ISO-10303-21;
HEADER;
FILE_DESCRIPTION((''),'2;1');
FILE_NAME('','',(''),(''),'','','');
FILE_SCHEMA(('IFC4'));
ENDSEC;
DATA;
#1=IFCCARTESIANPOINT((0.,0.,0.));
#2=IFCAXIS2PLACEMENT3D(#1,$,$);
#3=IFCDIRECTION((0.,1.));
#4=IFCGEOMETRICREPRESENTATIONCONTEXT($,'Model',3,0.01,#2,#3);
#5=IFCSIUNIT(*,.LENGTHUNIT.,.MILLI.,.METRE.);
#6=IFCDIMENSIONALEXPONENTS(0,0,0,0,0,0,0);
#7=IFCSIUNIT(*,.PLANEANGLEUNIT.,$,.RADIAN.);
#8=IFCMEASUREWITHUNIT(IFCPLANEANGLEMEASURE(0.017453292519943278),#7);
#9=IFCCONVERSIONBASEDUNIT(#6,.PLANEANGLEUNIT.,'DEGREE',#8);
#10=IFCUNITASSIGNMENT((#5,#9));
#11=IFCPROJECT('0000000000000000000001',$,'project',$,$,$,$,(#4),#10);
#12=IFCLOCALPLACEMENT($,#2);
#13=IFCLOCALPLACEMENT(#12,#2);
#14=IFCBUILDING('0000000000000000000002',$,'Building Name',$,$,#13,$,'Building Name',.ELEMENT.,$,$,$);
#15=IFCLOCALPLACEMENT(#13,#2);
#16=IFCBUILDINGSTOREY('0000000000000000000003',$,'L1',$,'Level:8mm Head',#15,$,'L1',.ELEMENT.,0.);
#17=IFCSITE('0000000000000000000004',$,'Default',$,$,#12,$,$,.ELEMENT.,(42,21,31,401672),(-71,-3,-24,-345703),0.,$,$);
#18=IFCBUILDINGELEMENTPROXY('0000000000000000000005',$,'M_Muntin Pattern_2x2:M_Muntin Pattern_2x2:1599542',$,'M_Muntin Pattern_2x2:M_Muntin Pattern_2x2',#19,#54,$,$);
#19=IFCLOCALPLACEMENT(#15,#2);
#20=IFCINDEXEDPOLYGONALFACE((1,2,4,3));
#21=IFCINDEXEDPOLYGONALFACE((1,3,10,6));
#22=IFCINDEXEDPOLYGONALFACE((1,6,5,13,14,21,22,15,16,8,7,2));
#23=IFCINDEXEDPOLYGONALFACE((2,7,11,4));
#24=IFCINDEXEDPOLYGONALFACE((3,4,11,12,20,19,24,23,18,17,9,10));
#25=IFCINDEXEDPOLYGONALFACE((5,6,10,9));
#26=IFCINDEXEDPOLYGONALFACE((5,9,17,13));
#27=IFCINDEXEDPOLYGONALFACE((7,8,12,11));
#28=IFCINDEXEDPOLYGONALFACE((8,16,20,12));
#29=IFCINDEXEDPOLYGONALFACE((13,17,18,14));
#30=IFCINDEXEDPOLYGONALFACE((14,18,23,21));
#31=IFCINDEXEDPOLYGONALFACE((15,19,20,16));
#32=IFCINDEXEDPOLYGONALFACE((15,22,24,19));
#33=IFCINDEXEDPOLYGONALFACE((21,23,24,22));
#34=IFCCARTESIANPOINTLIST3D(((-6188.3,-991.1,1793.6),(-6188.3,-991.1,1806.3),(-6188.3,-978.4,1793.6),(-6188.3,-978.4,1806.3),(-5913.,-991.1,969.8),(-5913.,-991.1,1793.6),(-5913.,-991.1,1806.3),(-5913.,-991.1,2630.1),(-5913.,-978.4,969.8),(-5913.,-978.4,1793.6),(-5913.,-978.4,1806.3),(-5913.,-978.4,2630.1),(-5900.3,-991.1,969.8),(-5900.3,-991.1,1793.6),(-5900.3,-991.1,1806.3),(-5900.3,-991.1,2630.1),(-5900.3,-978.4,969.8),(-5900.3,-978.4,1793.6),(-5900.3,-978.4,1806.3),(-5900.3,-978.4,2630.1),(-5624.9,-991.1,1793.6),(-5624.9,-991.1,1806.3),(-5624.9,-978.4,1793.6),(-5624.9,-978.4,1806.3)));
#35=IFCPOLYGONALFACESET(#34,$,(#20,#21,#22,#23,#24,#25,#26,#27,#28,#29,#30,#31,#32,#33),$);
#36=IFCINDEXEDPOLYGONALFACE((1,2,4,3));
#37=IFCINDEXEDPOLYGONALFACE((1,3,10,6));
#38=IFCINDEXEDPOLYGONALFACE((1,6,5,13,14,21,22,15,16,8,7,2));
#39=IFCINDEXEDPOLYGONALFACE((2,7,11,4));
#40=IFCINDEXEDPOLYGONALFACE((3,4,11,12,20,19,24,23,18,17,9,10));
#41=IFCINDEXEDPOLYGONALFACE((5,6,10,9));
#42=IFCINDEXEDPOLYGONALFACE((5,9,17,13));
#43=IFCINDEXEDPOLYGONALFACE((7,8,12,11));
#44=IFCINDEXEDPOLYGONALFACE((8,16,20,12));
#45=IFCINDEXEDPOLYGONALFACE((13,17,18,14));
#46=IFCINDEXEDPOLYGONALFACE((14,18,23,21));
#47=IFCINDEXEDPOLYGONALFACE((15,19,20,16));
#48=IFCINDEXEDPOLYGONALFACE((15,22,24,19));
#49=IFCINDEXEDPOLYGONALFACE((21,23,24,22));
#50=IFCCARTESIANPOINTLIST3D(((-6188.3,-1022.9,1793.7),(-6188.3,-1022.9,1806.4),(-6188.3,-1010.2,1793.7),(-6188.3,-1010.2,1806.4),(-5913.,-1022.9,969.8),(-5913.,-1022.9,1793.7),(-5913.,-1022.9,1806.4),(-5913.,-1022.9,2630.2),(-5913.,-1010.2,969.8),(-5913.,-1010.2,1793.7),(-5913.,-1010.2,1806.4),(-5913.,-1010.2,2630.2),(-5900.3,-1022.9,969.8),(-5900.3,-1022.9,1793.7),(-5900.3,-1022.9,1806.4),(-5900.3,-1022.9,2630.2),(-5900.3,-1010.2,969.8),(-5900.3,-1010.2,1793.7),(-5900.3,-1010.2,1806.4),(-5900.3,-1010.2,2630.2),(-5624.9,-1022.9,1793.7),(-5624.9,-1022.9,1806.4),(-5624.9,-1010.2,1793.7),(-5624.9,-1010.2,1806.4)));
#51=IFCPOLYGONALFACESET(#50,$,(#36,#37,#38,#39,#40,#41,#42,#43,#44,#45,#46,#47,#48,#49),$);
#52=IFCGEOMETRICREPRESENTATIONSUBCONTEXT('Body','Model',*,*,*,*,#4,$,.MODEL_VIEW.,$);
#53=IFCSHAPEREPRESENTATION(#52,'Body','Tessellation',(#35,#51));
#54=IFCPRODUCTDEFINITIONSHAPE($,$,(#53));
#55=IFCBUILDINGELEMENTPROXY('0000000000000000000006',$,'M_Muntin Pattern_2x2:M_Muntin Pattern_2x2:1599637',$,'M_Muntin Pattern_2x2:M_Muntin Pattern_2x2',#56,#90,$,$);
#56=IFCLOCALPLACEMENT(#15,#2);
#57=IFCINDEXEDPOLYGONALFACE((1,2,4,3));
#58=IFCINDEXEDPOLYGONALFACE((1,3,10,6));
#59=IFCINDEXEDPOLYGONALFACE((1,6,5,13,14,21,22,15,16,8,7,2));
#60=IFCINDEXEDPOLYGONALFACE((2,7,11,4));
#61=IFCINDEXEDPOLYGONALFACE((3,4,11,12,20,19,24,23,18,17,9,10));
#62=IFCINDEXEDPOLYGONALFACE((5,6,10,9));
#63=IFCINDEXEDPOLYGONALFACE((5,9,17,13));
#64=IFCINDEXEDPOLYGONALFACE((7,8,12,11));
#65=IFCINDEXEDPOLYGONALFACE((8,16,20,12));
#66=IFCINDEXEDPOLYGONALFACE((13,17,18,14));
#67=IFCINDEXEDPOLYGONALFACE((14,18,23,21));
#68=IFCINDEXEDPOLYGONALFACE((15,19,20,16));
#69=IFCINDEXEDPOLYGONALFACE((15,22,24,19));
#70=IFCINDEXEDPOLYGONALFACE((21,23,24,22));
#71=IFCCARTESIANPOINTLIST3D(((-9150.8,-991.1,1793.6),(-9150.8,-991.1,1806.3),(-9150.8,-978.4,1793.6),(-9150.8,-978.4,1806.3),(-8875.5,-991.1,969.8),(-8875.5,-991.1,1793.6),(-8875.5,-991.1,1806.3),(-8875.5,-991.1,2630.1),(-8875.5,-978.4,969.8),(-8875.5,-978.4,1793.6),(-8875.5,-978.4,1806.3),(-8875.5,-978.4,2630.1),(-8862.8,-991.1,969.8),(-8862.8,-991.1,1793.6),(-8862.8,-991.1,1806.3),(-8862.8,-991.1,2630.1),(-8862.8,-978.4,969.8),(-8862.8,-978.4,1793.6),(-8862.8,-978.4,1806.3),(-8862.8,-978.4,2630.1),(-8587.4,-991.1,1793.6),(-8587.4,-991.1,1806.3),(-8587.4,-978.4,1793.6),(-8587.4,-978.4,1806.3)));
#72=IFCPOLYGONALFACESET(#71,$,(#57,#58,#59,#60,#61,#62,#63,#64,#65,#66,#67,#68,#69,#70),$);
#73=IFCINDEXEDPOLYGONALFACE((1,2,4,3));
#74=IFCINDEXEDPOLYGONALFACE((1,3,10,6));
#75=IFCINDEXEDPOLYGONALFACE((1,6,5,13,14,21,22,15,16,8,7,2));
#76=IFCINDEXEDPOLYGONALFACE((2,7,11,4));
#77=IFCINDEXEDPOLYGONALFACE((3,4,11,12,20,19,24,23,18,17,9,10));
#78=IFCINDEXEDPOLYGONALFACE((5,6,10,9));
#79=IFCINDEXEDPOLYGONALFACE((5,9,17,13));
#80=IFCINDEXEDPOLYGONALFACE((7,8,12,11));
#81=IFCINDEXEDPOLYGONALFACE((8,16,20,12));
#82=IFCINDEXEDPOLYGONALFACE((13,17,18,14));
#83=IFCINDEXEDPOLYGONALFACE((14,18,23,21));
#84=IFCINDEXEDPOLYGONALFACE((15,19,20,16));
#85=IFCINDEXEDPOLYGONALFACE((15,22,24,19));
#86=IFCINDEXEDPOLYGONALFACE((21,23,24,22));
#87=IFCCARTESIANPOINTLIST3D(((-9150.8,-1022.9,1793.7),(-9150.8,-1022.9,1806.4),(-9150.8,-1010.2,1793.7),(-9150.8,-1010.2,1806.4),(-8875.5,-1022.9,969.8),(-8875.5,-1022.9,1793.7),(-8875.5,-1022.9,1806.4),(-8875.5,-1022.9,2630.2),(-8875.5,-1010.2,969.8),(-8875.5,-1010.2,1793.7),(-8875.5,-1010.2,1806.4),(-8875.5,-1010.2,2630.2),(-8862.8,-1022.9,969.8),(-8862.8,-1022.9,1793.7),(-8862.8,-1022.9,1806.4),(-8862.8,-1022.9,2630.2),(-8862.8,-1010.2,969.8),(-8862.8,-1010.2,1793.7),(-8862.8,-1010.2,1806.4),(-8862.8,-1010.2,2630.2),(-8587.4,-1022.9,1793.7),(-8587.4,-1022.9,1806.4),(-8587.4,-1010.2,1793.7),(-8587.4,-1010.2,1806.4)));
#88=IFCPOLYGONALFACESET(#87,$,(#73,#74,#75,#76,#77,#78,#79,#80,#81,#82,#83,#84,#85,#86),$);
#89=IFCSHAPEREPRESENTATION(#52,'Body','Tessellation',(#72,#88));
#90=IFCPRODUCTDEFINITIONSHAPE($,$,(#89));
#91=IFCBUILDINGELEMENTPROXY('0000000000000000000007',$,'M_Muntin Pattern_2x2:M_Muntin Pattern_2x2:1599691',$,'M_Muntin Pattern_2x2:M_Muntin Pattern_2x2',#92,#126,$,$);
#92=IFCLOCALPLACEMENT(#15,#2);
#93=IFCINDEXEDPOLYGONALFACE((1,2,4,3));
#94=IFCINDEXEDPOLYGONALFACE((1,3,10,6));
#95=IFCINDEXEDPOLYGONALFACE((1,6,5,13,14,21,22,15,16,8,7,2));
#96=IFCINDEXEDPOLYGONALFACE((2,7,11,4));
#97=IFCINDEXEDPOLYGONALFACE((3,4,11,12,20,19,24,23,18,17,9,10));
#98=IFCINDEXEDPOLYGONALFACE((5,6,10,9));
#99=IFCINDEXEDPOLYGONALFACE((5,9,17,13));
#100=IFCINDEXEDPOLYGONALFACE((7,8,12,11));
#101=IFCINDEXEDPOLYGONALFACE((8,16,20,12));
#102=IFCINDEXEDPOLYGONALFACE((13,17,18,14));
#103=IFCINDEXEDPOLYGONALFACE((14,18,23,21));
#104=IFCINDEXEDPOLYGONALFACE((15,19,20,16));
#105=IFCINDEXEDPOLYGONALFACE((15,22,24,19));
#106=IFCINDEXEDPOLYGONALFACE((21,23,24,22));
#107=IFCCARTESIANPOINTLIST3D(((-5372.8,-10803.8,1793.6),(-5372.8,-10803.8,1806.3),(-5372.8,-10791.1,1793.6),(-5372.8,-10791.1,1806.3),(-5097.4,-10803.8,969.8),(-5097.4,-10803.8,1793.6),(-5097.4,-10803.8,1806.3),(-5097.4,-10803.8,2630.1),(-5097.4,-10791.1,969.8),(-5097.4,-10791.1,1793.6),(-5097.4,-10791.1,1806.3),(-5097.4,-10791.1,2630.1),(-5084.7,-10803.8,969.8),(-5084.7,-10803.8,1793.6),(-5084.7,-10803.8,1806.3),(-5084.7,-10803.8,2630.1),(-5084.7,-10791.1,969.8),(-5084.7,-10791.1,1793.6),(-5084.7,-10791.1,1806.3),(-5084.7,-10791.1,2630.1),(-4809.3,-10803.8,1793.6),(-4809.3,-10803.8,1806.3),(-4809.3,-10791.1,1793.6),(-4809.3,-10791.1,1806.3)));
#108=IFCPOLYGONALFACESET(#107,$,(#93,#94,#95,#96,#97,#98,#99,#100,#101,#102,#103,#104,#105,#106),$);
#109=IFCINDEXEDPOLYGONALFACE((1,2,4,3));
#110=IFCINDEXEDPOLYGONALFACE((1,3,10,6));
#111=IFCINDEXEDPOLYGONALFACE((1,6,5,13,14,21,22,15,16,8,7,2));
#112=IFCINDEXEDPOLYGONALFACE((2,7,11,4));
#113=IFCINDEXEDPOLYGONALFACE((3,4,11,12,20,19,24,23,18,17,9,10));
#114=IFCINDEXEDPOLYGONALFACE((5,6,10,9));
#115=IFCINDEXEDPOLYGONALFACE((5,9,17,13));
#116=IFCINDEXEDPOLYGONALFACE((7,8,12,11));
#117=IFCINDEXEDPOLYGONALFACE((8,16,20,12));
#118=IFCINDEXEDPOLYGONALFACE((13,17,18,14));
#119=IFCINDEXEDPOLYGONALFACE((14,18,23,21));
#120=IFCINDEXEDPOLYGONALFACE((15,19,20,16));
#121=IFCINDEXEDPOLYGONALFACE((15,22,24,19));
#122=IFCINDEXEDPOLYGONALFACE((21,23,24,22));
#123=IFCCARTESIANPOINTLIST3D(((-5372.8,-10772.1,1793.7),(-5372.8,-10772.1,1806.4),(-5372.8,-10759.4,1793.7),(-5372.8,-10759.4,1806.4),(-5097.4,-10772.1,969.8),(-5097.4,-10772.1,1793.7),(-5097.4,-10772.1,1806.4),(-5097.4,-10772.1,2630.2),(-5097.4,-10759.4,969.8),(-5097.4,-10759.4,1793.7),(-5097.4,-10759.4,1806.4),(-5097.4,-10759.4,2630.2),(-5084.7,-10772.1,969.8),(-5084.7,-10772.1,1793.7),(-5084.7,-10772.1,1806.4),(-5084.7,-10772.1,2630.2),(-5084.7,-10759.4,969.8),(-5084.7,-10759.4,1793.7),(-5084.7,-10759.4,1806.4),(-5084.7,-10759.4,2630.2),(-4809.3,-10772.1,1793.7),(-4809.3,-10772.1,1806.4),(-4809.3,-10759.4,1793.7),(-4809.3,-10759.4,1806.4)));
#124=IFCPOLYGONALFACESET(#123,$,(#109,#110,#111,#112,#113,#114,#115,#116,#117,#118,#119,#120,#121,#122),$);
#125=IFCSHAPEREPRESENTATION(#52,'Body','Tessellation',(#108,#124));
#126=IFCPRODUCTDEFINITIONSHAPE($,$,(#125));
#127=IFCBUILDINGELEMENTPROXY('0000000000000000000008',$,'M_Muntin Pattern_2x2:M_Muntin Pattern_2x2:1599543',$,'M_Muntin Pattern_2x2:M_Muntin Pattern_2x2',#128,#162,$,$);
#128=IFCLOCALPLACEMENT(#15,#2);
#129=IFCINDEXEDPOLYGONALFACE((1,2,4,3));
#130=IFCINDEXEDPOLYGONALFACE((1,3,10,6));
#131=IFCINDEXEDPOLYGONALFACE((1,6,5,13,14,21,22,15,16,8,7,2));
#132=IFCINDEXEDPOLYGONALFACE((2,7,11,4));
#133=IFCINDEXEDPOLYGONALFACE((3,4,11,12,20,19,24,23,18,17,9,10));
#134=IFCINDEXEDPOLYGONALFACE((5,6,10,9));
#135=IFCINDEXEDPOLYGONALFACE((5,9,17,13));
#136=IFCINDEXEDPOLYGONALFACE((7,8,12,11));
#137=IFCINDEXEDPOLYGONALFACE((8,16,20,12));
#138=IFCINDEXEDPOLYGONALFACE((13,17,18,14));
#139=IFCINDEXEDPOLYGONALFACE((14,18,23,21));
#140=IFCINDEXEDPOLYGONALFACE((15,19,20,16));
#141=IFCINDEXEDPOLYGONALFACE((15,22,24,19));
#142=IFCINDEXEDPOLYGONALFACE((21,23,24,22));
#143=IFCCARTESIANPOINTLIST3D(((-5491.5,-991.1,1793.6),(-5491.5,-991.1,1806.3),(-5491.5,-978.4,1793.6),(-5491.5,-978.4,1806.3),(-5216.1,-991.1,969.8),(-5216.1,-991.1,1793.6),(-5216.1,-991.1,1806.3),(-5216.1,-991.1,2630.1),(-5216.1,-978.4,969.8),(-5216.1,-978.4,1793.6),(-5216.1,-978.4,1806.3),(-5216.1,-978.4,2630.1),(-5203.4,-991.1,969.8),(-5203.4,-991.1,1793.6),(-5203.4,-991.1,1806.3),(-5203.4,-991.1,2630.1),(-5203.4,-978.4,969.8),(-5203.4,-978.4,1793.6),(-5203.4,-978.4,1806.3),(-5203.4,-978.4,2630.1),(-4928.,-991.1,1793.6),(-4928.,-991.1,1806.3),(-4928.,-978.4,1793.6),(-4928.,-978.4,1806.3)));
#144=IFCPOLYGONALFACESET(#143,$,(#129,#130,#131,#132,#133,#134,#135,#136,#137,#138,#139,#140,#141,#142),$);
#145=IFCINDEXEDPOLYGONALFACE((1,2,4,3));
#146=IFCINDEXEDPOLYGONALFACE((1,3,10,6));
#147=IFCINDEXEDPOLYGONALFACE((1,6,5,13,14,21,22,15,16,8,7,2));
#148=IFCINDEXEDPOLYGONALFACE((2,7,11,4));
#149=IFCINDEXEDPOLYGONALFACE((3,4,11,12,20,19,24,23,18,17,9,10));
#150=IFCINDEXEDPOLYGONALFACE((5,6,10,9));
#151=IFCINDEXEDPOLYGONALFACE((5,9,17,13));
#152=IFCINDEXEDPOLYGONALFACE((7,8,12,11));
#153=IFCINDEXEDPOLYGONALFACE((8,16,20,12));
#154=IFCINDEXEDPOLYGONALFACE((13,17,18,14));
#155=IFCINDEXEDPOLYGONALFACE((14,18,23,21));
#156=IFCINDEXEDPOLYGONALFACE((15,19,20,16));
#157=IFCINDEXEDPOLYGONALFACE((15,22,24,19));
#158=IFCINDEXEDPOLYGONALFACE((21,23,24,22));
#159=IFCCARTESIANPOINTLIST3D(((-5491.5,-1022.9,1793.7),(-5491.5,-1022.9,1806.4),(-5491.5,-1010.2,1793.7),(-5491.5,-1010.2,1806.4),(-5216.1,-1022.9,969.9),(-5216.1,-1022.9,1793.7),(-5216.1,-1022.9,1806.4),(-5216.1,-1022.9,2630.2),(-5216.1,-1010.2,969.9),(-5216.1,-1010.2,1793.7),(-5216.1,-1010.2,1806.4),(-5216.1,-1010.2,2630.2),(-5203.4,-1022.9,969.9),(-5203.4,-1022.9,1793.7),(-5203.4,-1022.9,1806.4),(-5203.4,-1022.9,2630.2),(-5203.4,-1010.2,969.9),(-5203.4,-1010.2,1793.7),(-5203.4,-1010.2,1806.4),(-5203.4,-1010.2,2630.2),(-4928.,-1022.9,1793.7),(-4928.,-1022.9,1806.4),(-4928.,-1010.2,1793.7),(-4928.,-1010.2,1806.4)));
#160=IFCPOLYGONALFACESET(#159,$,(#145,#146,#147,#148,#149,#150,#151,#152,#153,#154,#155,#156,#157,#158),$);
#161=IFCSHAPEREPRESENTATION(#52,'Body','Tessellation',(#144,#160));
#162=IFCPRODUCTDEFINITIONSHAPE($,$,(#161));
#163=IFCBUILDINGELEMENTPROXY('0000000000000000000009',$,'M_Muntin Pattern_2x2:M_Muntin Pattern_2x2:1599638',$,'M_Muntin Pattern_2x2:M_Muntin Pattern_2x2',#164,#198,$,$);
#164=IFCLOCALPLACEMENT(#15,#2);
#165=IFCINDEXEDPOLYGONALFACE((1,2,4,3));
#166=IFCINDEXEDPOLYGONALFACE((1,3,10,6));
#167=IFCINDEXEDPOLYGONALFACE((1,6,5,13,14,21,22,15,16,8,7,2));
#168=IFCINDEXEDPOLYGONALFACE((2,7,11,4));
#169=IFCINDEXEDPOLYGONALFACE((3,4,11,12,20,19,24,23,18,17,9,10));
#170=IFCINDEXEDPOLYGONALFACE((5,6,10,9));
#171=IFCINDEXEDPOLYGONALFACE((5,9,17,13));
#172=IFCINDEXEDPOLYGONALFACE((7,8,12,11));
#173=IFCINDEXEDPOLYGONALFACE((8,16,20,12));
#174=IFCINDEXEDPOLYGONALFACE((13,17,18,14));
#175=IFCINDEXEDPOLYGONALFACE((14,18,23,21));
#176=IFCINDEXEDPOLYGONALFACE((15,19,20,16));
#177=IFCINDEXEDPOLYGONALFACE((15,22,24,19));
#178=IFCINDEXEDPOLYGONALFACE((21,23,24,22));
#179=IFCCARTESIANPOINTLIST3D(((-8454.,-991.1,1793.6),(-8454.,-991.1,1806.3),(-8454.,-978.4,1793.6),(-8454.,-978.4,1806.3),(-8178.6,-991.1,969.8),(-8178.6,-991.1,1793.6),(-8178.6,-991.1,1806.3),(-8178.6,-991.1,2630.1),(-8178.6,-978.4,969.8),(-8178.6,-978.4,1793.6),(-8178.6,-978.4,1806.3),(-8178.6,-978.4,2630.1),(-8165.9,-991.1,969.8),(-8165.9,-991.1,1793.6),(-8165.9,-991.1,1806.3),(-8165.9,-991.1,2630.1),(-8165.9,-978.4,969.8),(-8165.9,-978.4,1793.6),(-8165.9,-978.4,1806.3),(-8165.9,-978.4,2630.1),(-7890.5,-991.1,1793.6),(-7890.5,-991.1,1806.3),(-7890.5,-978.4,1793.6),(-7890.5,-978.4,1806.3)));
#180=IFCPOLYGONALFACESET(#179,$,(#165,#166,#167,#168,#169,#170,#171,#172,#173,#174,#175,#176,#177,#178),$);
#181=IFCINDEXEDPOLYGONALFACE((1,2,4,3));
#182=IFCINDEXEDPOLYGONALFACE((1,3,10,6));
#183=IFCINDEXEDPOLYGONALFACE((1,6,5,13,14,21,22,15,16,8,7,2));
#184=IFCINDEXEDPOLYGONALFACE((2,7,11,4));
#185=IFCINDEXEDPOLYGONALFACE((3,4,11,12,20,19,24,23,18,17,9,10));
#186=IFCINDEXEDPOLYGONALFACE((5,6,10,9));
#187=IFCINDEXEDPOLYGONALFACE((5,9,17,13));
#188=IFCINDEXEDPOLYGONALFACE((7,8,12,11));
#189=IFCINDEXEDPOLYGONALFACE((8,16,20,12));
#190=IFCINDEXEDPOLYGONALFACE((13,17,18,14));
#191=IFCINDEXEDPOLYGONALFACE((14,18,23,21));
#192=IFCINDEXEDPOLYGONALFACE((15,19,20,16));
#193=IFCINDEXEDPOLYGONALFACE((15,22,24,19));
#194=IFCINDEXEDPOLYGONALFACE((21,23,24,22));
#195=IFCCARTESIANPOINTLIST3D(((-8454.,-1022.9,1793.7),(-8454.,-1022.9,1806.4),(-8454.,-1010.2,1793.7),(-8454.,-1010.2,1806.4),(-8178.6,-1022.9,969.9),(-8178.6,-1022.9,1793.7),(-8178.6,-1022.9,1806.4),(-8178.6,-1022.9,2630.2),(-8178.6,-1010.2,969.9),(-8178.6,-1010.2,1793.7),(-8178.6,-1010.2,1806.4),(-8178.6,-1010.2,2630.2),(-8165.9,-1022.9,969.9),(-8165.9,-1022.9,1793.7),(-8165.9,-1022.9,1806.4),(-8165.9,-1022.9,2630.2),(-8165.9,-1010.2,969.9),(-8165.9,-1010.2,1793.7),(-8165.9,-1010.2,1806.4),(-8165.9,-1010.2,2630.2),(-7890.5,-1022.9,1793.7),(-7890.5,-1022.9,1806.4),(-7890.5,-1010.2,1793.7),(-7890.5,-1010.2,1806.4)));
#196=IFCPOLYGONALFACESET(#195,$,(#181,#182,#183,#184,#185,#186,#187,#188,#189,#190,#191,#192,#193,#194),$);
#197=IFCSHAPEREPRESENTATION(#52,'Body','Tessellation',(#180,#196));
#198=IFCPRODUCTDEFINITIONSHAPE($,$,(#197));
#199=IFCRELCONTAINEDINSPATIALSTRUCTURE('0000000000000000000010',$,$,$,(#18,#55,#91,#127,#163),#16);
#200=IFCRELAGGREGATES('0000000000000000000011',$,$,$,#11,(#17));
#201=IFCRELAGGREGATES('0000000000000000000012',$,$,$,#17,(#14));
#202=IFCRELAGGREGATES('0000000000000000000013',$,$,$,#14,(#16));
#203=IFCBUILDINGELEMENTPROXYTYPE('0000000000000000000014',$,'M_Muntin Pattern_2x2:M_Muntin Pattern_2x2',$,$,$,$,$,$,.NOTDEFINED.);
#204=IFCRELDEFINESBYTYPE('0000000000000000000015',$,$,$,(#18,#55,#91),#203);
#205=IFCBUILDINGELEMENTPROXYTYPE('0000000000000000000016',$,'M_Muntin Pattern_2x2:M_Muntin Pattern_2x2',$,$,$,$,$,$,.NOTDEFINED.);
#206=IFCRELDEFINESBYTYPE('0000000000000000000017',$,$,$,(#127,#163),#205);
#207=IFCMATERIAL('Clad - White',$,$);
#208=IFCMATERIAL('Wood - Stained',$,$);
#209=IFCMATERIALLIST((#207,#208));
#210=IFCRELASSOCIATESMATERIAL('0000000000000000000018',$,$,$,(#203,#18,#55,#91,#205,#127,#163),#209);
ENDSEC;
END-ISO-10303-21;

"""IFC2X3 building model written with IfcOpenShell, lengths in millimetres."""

from ifc_helpers import new_model, entity, si_unit, converted_unit, direction, frame, origin, place, context, subcontext, project, spatial, polyline, outline, extrude, source, transform, mapped, material, material_list, type_object, type_shapes, element, save


model = new_model("IFC2X3")

# Units and contexts
model_context = context("Model", 3, precision=0.01, world=origin(), true_north=direction((0.0, 1.0)))
body_context = subcontext(model_context, "Body", "Model", "MODEL_VIEW")
ifc_project = project(units=[si_unit("LENGTHUNIT", "METRE", prefix="MILLI"), converted_unit("PLANEANGLEUNIT", "DEGREE", entity("IfcPlaneAngleMeasure", 0.017453292519943278), si_unit("PLANEANGLEUNIT", "RADIAN"), dimensions=[0, 0, 0, 0, 0, 0, 0])], contexts=[model_context])

# Site, building, storey
site_placement = place(None, origin())
site = spatial("IfcSite", under=ifc_project, at=site_placement, Name="Default", CompositionType="ELEMENT", RefLatitude=(42, 21, 31, 401672), RefLongitude=(-71, -3, -24, -345703), RefElevation=0.0)
building_placement = place(site_placement, origin())
building = spatial("IfcBuilding", under=site, at=building_placement, Name="Building Name", LongName="Building Name", CompositionType="ELEMENT")
storey_placement = place(building_placement, origin())
storey = spatial("IfcBuildingStorey", under=building, at=storey_placement, Name="L1", ObjectType="Level:8mm Head", LongName="L1", CompositionType="ELEMENT", Elevation=0.0)

# Building element proxies
ifc_material_1 = material(Name="Clad - White")
ifc_material_2 = material(Name="Wood - Stained")
ifc_material_list = material_list([ifc_material_1, ifc_material_2])
building_element_proxy_type_1 = type_object("IfcBuildingElementProxyType", Name="M_Muntin Pattern_2x2:M_Muntin Pattern_2x2", PredefinedType="NOTDEFINED", material=ifc_material_list)
shared_shape_1 = source(origin(), body_context, "Body", "SweptSolid", [
    extrude(outline(polyline([(6.4, -6.4), (830.1, -6.4), (830.1, 6.3), (6.4, 6.3), (6.4, 281.7), (-6.3, 281.7), (-6.3, 6.3), (-830.2, 6.3), (-830.2, -6.4), (-6.3, -6.4), (-6.3, -281.7), (6.4, -281.7), (6.4, -6.4)])), frame((0.0, 9.5, 830.1), z_axis=(0.0, 1.0, 0.0), x_axis=(0.0, 0.0, 1.0)), (0.0, 0.0, 1.0), 12.7),
    extrude(outline(polyline([(6.4, -6.4), (830.2, -6.4), (830.2, 6.3), (6.4, 6.3), (6.4, 281.7), (-6.3, 281.7), (-6.3, 6.3), (-830.2, 6.3), (-830.2, -6.4), (-6.3, -6.4), (-6.3, -281.7), (6.4, -281.7), (6.4, -6.4)])), frame((0.0, -22.2, 830.2), z_axis=(0.0, 1.0, 0.0), x_axis=(0.0, 0.0, 1.0)), (0.0, 0.0, 1.0), 12.7),
])
type_shapes(building_element_proxy_type_1, [shared_shape_1])
for number, where, name in (
    (1, (-5906.6, -1000.6, 969.8), "M_Muntin Pattern_2x2:M_Muntin Pattern_2x2:1599542"),
    (2, (-8869.1, -1000.6, 969.8), "M_Muntin Pattern_2x2:M_Muntin Pattern_2x2:1599637"),
):
    element("IfcBuildingElementProxy", number, at=place(storey_placement, frame(where)), inside=storey, type_object=building_element_proxy_type_1, material=ifc_material_list, Name=name, ObjectType="M_Muntin Pattern_2x2:M_Muntin Pattern_2x2", context=body_context, shape_type="MappedRepresentation", body=[
        mapped(shared_shape_1, transform((0.0, 0.0, 0.0), scale=1.0)),
    ])
proxy_1_placement = place(storey_placement, frame((-5091.0, -10781.6, 969.8), z_axis=(0.0, 0.0, 1.0), x_axis=(-1.0, 0.0, 0.0)))
element("IfcBuildingElementProxy", 3, at=proxy_1_placement, inside=storey, type_object=building_element_proxy_type_1, material=ifc_material_list, Name="M_Muntin Pattern_2x2:M_Muntin Pattern_2x2:1599691", ObjectType="M_Muntin Pattern_2x2:M_Muntin Pattern_2x2", context=body_context, shape_type="MappedRepresentation", body=[
    mapped(shared_shape_1, transform((0.0, 0.0, 0.0), scale=1.0)),
])
building_element_proxy_type_2 = type_object("IfcBuildingElementProxyType", Name="M_Muntin Pattern_2x2:M_Muntin Pattern_2x2", PredefinedType="NOTDEFINED", material=ifc_material_list)
shared_shape_2 = source(origin(), body_context, "Body", "SweptSolid", [
    extrude(outline(polyline([(6.4, -6.4), (830.1, -6.4), (830.1, 6.3), (6.4, 6.3), (6.4, 281.7), (-6.3, 281.7), (-6.3, 6.3), (-830.2, 6.3), (-830.2, -6.4), (-6.3, -6.4), (-6.3, -281.7), (6.4, -281.7), (6.4, -6.4)])), frame((0.0, -22.2, 830.1), z_axis=(0.0, 1.0, 0.0), x_axis=(0.0, 0.0, 1.0)), (0.0, 0.0, 1.0), 12.7),
    extrude(outline(polyline([(6.4, -6.4), (830.2, -6.4), (830.2, 6.3), (6.4, 6.3), (6.4, 281.7), (-6.3, 281.7), (-6.3, 6.3), (-830.2, 6.3), (-830.2, -6.4), (-6.3, -6.4), (-6.3, -281.7), (6.4, -281.7), (6.4, -6.4)])), frame((0.0, 9.5, 830.2), z_axis=(0.0, 1.0, 0.0), x_axis=(0.0, 0.0, 1.0)), (0.0, 0.0, 1.0), 12.7),
])
type_shapes(building_element_proxy_type_2, [shared_shape_2])
for number, where, z_axis, x_axis, name in (
    (4, (-5209.8, -1000.6, 969.9), (0.0, 0.0, 1.0), (-1.0, 0.0, 0.0), "M_Muntin Pattern_2x2:M_Muntin Pattern_2x2:1599543"),
    (5, (-8172.3, -1000.6, 969.9), (0.0, 0.0, 1.0), (-1.0, 0.0, 0.0), "M_Muntin Pattern_2x2:M_Muntin Pattern_2x2:1599638"),
):
    element("IfcBuildingElementProxy", number, at=place(storey_placement, frame(where, z_axis=z_axis, x_axis=x_axis)), inside=storey, type_object=building_element_proxy_type_2, material=ifc_material_list, Name=name, ObjectType="M_Muntin Pattern_2x2:M_Muntin Pattern_2x2", context=body_context, shape_type="MappedRepresentation", body=[
        mapped(shared_shape_2, transform((0.0, 0.0, 0.0), scale=1.0)),
    ])

save(model, "model.ifc")
